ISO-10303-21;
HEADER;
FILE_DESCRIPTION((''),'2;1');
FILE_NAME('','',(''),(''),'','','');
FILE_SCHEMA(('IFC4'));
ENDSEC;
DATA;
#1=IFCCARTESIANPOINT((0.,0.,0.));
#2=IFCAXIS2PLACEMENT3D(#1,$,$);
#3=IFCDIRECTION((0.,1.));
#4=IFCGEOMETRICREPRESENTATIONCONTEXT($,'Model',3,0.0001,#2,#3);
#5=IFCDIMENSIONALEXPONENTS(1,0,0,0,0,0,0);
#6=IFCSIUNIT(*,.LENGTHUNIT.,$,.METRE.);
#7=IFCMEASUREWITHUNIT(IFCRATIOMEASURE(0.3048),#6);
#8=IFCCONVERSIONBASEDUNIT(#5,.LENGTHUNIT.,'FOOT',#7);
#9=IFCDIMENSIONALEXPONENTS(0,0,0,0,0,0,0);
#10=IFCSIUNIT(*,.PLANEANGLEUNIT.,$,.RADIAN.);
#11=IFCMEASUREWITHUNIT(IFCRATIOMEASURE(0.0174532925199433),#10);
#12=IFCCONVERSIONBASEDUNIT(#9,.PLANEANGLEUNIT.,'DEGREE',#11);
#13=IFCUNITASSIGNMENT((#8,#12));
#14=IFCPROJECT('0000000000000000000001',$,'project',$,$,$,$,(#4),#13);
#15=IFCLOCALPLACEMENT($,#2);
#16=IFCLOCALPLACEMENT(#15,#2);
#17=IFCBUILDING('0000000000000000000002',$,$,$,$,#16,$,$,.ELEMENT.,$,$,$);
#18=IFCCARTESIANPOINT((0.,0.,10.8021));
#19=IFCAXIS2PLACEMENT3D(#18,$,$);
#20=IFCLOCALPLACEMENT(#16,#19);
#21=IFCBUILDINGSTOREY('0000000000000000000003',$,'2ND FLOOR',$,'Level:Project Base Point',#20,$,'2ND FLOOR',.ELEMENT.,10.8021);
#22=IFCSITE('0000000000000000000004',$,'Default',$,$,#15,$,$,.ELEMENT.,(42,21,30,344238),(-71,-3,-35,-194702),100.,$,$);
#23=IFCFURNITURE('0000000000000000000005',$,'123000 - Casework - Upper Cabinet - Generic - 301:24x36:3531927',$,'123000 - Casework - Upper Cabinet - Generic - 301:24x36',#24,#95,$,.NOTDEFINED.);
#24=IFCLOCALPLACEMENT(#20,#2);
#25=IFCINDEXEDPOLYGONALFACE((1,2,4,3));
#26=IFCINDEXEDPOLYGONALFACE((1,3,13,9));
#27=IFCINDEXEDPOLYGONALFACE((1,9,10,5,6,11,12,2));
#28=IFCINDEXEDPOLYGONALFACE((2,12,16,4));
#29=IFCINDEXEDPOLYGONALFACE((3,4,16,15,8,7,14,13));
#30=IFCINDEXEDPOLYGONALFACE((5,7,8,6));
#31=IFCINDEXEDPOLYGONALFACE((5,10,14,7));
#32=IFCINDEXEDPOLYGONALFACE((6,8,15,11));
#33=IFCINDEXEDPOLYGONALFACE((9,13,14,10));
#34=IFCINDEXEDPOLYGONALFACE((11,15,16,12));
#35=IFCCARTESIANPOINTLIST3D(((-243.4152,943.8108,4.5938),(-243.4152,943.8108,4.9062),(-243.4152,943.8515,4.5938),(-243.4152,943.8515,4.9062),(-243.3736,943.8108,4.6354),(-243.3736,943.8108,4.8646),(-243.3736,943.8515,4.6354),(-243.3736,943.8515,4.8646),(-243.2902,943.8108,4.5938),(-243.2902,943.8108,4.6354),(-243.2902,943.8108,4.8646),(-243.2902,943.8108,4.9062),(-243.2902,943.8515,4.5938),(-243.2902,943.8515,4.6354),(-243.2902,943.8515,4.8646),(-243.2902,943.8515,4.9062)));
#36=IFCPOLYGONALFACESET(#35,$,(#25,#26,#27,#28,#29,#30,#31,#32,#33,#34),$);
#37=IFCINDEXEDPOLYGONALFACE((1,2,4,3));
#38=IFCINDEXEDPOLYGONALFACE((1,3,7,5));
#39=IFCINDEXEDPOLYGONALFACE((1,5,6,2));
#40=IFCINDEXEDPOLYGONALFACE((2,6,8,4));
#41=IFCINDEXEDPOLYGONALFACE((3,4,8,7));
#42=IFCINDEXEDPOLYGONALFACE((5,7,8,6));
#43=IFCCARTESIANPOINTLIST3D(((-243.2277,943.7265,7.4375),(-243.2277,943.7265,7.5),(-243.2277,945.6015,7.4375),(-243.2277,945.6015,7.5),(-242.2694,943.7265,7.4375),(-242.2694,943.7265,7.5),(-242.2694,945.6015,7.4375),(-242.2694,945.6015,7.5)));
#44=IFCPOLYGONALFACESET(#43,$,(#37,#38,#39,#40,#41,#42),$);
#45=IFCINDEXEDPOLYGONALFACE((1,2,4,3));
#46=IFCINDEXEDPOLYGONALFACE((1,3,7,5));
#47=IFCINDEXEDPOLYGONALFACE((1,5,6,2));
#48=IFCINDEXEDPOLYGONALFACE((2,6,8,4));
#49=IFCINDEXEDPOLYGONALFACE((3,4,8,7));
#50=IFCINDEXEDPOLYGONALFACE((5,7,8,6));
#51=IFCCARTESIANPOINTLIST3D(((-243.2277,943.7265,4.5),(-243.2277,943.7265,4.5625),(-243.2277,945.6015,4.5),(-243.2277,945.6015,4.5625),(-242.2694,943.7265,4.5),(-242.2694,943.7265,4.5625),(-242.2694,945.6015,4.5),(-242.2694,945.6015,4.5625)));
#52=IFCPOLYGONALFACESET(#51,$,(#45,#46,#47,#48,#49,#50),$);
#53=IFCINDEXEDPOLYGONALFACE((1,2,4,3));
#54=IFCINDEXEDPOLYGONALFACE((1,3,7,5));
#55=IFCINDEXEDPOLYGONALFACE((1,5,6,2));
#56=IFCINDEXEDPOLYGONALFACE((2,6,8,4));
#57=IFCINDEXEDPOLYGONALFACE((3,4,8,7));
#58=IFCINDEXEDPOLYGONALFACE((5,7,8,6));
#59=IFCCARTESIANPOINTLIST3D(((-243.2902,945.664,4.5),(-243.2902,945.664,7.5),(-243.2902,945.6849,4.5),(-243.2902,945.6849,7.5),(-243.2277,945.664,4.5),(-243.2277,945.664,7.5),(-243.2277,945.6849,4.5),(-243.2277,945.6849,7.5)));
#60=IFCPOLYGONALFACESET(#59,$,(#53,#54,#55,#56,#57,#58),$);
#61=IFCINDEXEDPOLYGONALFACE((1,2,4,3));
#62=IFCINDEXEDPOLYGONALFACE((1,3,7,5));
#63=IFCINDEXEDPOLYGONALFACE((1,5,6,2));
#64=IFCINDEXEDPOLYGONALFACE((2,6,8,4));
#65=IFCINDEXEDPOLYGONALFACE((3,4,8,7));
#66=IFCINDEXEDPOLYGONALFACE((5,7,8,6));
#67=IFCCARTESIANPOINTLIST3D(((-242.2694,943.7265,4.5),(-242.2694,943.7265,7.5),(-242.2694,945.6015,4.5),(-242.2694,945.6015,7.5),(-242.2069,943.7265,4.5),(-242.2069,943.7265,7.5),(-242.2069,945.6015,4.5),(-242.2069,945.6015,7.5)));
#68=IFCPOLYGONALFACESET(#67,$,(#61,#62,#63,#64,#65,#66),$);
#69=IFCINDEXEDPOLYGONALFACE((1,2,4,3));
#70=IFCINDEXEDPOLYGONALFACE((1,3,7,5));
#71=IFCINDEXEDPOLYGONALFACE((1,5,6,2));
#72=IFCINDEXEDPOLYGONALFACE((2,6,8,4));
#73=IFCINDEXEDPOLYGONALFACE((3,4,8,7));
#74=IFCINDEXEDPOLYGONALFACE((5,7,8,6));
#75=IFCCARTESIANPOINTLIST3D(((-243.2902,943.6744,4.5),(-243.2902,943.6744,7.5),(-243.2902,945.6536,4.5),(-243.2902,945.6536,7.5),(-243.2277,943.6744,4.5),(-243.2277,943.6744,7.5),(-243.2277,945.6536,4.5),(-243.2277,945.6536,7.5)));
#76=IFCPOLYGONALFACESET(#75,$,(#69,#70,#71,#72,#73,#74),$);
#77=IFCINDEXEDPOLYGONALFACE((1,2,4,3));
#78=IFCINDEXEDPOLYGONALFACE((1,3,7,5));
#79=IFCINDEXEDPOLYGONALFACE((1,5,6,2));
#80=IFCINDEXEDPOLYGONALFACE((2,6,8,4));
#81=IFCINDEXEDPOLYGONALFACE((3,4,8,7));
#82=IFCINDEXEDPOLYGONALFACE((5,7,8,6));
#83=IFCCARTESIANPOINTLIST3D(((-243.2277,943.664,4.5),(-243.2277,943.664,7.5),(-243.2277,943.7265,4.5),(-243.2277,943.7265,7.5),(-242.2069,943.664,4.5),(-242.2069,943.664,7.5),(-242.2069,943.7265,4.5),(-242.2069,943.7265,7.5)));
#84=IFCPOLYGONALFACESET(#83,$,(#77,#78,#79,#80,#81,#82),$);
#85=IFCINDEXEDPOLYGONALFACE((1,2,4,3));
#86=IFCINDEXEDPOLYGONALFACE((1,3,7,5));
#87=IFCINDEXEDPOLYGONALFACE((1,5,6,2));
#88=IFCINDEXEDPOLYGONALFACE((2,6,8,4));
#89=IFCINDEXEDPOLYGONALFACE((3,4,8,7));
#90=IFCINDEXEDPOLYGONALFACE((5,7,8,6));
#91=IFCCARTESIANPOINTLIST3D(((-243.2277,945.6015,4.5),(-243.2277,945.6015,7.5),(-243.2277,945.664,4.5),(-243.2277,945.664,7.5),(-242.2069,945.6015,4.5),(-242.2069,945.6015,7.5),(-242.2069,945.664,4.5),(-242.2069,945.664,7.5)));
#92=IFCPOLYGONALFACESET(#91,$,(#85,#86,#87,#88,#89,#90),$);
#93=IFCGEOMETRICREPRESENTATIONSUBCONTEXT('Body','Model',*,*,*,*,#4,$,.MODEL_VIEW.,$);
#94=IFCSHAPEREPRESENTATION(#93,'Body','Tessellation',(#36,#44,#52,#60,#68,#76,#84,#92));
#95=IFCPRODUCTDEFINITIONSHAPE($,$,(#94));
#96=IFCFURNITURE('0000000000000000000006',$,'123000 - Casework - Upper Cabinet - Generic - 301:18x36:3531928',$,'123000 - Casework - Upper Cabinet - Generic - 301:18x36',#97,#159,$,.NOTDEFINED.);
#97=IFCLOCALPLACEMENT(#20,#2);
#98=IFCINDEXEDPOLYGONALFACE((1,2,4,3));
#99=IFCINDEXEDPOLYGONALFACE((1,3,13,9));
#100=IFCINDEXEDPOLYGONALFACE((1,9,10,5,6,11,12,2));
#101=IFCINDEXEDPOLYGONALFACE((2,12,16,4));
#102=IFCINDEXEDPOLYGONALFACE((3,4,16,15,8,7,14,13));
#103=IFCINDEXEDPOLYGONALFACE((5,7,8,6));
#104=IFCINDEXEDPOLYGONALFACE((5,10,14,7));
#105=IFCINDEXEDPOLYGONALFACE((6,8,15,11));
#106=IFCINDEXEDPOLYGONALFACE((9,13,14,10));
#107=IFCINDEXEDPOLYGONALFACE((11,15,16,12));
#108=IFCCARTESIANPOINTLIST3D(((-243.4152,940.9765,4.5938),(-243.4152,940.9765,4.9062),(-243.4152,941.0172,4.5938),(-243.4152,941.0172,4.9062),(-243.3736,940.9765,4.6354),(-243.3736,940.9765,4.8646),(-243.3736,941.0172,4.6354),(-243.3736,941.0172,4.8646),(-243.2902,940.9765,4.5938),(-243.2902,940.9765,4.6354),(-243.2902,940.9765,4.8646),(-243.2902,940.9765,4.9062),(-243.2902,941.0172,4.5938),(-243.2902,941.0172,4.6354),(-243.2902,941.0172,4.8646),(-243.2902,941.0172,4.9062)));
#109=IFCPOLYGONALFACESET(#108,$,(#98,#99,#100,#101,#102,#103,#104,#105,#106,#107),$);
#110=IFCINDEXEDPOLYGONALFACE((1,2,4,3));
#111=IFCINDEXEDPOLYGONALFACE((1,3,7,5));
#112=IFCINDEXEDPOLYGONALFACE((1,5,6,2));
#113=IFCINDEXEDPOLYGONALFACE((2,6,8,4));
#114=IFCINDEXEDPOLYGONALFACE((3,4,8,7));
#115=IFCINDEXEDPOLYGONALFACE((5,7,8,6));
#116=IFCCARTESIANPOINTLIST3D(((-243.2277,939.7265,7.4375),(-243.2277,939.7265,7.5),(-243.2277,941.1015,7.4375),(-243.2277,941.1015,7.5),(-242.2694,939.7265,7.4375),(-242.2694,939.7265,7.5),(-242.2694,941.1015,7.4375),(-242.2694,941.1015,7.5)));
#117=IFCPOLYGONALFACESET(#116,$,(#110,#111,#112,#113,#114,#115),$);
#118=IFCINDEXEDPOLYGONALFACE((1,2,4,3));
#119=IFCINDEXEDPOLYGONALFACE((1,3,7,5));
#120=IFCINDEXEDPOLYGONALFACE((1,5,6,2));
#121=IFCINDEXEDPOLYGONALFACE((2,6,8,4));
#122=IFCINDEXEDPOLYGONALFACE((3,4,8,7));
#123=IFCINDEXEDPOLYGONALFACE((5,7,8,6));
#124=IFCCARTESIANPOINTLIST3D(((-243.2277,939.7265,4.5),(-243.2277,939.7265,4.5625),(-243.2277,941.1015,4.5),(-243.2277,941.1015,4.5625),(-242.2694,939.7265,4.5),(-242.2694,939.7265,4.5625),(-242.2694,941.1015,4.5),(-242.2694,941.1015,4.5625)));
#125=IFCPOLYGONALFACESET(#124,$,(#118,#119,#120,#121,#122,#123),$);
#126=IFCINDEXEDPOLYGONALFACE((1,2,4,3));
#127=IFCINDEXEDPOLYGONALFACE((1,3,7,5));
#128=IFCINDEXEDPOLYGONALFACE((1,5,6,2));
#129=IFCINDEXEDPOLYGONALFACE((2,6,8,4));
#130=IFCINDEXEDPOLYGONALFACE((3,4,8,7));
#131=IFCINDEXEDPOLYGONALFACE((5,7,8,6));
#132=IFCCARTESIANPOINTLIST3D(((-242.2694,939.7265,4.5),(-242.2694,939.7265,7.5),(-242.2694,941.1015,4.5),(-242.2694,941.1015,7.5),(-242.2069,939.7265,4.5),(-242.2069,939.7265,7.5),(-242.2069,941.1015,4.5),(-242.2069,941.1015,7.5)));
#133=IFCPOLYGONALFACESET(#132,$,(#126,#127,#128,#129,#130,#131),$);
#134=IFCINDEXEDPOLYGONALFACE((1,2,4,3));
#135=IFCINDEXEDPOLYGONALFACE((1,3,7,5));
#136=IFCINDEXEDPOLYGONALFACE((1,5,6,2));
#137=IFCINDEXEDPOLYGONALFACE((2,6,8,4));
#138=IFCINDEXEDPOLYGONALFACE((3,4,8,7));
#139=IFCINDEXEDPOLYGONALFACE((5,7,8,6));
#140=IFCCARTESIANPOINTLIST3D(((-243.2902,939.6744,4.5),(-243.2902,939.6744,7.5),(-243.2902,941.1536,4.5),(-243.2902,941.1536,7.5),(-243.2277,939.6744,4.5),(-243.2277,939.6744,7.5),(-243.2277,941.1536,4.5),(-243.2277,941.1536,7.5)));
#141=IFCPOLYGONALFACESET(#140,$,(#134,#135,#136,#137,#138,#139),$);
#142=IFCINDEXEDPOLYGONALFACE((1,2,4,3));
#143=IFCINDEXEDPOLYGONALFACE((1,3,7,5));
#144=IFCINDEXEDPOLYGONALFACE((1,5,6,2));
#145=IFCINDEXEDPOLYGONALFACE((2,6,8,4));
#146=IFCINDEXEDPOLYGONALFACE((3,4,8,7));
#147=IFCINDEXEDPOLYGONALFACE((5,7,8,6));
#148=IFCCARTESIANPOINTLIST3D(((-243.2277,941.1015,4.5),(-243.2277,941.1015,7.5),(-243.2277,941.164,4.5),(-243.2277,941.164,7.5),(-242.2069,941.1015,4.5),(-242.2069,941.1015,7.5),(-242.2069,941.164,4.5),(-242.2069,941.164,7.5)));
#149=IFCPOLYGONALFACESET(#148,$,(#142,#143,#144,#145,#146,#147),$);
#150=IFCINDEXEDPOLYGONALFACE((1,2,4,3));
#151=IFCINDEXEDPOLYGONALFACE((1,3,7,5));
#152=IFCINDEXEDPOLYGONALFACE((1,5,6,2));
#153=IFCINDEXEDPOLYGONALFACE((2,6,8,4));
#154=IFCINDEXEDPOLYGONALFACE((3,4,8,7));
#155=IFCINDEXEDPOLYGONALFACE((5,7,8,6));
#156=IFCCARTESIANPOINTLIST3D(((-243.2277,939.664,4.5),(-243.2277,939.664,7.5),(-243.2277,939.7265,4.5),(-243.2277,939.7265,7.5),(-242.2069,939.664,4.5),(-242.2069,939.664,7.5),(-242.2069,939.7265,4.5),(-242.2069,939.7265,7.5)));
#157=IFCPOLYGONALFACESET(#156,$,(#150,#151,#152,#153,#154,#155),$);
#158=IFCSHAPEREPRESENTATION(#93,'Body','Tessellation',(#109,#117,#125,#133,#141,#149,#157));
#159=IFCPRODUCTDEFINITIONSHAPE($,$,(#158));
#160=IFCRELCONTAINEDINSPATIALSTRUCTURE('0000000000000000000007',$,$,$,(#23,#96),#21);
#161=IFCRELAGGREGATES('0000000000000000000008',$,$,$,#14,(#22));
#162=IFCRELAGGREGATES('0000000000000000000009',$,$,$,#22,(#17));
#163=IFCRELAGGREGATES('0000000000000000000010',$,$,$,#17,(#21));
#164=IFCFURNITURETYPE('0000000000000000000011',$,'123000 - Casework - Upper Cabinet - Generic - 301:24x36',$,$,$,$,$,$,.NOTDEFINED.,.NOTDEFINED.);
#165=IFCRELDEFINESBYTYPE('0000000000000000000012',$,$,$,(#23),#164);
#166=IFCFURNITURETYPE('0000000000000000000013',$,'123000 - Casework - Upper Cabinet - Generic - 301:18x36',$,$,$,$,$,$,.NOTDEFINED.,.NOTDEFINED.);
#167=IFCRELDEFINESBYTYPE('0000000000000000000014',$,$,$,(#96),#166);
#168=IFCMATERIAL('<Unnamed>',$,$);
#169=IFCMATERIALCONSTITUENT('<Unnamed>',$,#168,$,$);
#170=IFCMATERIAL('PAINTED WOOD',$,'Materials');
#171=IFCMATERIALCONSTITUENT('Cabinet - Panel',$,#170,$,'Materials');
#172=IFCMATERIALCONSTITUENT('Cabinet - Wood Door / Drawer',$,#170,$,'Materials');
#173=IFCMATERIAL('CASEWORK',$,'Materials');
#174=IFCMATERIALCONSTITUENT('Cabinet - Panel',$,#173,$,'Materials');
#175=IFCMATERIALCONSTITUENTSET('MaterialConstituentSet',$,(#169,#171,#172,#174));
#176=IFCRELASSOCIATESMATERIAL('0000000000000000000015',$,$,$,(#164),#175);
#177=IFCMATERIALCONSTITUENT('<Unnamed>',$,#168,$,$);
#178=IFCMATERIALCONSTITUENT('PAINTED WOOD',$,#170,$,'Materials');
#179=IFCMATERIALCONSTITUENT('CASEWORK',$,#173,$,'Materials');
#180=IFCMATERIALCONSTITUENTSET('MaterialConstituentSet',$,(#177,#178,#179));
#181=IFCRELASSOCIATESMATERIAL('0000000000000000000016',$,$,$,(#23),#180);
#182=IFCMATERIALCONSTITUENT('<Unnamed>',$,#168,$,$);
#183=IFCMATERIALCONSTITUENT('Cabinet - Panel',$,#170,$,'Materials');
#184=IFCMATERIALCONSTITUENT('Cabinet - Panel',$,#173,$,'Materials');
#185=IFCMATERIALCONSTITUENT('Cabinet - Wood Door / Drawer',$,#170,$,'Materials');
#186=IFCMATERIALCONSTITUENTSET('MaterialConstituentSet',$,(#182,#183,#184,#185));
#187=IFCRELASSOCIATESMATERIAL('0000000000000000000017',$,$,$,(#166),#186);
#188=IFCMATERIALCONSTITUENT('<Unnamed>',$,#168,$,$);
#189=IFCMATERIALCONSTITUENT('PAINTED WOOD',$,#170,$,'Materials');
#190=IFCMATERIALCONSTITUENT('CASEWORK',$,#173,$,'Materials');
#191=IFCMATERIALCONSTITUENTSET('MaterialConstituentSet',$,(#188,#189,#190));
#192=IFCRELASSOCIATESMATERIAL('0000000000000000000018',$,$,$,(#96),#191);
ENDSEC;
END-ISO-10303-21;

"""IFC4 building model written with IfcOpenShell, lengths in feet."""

from ifc_helpers import new_model, entity, si_unit, converted_unit, direction, frame, frame_2d, origin, origin_2d_with_axis, place, context, subcontext, project, spatial, polyline, rectangle, outline, extrude, source, transform, mapped, material, constituent, constituent_set, type_object, type_shapes, element, save


model = new_model("IFC4")

# Units and contexts
model_context = context("Model", 3, precision=0.0001, world=origin(), true_north=direction((0.0, 1.0)))
body_context = subcontext(model_context, "Body", "Model", "MODEL_VIEW")
ifc_project = project(units=[converted_unit("LENGTHUNIT", "FOOT", entity("IfcRatioMeasure", 0.3048), si_unit("LENGTHUNIT", "METRE"), dimensions=[1, 0, 0, 0, 0, 0, 0]), converted_unit("PLANEANGLEUNIT", "DEGREE", entity("IfcRatioMeasure", 0.0174532925199433), si_unit("PLANEANGLEUNIT", "RADIAN"), dimensions=[0, 0, 0, 0, 0, 0, 0])], contexts=[model_context])

# Site, building, storey
site_placement = place(None, origin())
site = spatial("IfcSite", under=ifc_project, at=site_placement, Name="Default", CompositionType="ELEMENT", RefLatitude=(42, 21, 30, 344238), RefLongitude=(-71, -3, -35, -194702), RefElevation=100.0)
building_placement = place(site_placement, origin())
building = spatial("IfcBuilding", under=site, at=building_placement, CompositionType="ELEMENT")
storey_placement = place(building_placement, frame((0.0, 0.0, 10.8021)))
storey = spatial("IfcBuildingStorey", under=building, at=storey_placement, Name="2ND FLOOR", ObjectType="Level:Project Base Point", LongName="2ND FLOOR", CompositionType="ELEMENT", Elevation=10.8021)

# Furniture
ifc_material_1 = material(Name="CASEWORK", Category="Materials")
ifc_material_2 = material(Name="<Unnamed>")
ifc_material_3 = material(Name="PAINTED WOOD", Category="Materials")
ifc_constituent_1 = constituent(ifc_material_2, Name="<Unnamed>")
ifc_constituent_2 = constituent(ifc_material_3, Name="PAINTED WOOD", Category="Materials")
ifc_constituent_3 = constituent(ifc_material_1, Name="CASEWORK", Category="Materials")
ifc_constituent_set_1 = constituent_set(constituents=[ifc_constituent_1, ifc_constituent_2, ifc_constituent_3], Name="MaterialConstituentSet")
ifc_constituent_4 = constituent(ifc_material_2, Name="<Unnamed>")
ifc_constituent_5 = constituent(ifc_material_3, Name="Cabinet - Panel", Category="Materials")
ifc_constituent_6 = constituent(ifc_material_3, Name="Cabinet - Wood Door / Drawer", Category="Materials")
ifc_constituent_7 = constituent(ifc_material_1, Name="Cabinet - Panel", Category="Materials")
ifc_constituent_set_2 = constituent_set(constituents=[ifc_constituent_4, ifc_constituent_5, ifc_constituent_6, ifc_constituent_7], Name="MaterialConstituentSet")
furniture_type_1 = type_object("IfcFurnitureType", Name="123000 - Casework - Upper Cabinet - Generic - 301:24x36", AssemblyPlace="NOTDEFINED", PredefinedType="NOTDEFINED", material=ifc_constituent_set_2)
shared_shape_1 = source(origin(), body_context, "Body", "SweptSolid", [
    extrude(outline(polyline([(-0.0521, -0.1146), (-0.0521, -0.1562), (0.0729, -0.1562), (0.0729, 0.1562), (-0.0521, 0.1562), (-0.0521, 0.1146), (0.0313, 0.1146), (0.0313, -0.1146), (-0.0521, -0.1146)])), frame((0.1468, 1.1354, 0.25), z_axis=(-1.0, 0.0, 0.0), x_axis=(0.0, 1.0, 0.0)), (0.0, 0.0, -1.0), 0.0407),
    extrude(rectangle(XDim=0.9583, YDim=1.875, at=frame_2d((0.0, 0.0), x_axis=(1.0, 0.0))), frame((1.0, 0.5417, 2.9375), z_axis=(0.0, 0.0, 1.0), x_axis=(0.0, 1.0, 0.0)), (0.0, 0.0, 1.0), 0.0625),
    extrude(rectangle(XDim=0.9583, YDim=1.875, at=frame_2d((0.0, 0.0), x_axis=(1.0, 0.0))), frame((1.0, 0.5417, 0.0), z_axis=(0.0, 0.0, 1.0), x_axis=(0.0, 1.0, 0.0)), (0.0, 0.0, 1.0), 0.0625),
    extrude(rectangle(XDim=0.0208, YDim=0.0625, at=frame_2d((0.0, 0.0), x_axis=(1.0, 0.0))), frame((2.0104, 1.0521, 0.0)), (0.0, 0.0, 1.0), 3.0),
    extrude(rectangle(XDim=1.875, YDim=0.0625, at=origin_2d_with_axis()), frame((1.0, 0.0313, 0.0), z_axis=(0.0, 0.0, 1.0), x_axis=(-1.0, 0.0, 0.0)), (0.0, 0.0, 1.0), 3.0),
    extrude(rectangle(XDim=1.9792, YDim=0.0625, at=frame_2d((0.0, 0.0), x_axis=(1.0, 0.0))), frame((1.0, 1.0521, 0.0)), (0.0, 0.0, 1.0), 3.0),
    extrude(rectangle(XDim=1.0208, YDim=0.0625, at=origin_2d_with_axis()), frame((0.0312, 0.5104, 0.0), z_axis=(0.0, 0.0, 1.0), x_axis=(0.0, 1.0, 0.0)), (0.0, 0.0, 1.0), 3.0),
    extrude(rectangle(XDim=1.0208, YDim=0.0625, at=origin_2d_with_axis()), frame((1.9688, 0.5104, 0.0), z_axis=(0.0, 0.0, 1.0), x_axis=(0.0, 1.0, 0.0)), (0.0, 0.0, 1.0), 3.0),
])
type_shapes(furniture_type_1, [shared_shape_1])
furniture_1_placement = place(storey_placement, frame((-242.2069, 943.664, 4.5), z_axis=(0.0, 0.0, 1.0), x_axis=(0.0, 1.0, 0.0)))
element("IfcFurniture", 1, at=furniture_1_placement, inside=storey, type_object=furniture_type_1, material=ifc_constituent_set_1, Name="123000 - Casework - Upper Cabinet - Generic - 301:24x36:3531927", ObjectType="123000 - Casework - Upper Cabinet - Generic - 301:24x36", PredefinedType="NOTDEFINED", context=body_context, shape_type="MappedRepresentation", body=[
    mapped(shared_shape_1, transform((0.0, 0.0, 0.0), scale=1.0)),
])
ifc_constituent_8 = constituent(ifc_material_2, Name="<Unnamed>")
ifc_constituent_9 = constituent(ifc_material_3, Name="PAINTED WOOD", Category="Materials")
ifc_constituent_10 = constituent(ifc_material_1, Name="CASEWORK", Category="Materials")
ifc_constituent_set_3 = constituent_set(constituents=[ifc_constituent_8, ifc_constituent_9, ifc_constituent_10], Name="MaterialConstituentSet")
ifc_constituent_11 = constituent(ifc_material_2, Name="<Unnamed>")
ifc_constituent_12 = constituent(ifc_material_3, Name="Cabinet - Panel", Category="Materials")
ifc_constituent_13 = constituent(ifc_material_1, Name="Cabinet - Panel", Category="Materials")
ifc_constituent_14 = constituent(ifc_material_3, Name="Cabinet - Wood Door / Drawer", Category="Materials")
ifc_constituent_set_4 = constituent_set(constituents=[ifc_constituent_11, ifc_constituent_12, ifc_constituent_13, ifc_constituent_14], Name="MaterialConstituentSet")
furniture_type_2 = type_object("IfcFurnitureType", Name="123000 - Casework - Upper Cabinet - Generic - 301:18x36", AssemblyPlace="NOTDEFINED", PredefinedType="NOTDEFINED", material=ifc_constituent_set_4)
shared_shape_2 = source(origin(), body_context, "Body", "SweptSolid", [
    extrude(outline(polyline([(0.1146, -0.0521), (0.1562, -0.0521), (0.1562, 0.0729), (-0.1562, 0.0729), (-0.1562, -0.0521), (-0.1146, -0.0521), (-0.1146, 0.0313), (0.1146, 0.0313), (0.1146, -0.0521)])), frame((0.1468, 0.0729, 0.25), z_axis=(1.0, 0.0, 0.0), x_axis=(0.0, 0.0, 1.0)), (0.0, 0.0, 1.0), 0.0407),
    extrude(rectangle(XDim=1.375, YDim=0.9583, at=frame_2d((0.0, 0.0), x_axis=(1.0, 0.0))), frame((0.75, 0.6666, 2.9375), z_axis=(0.0, 0.0, 1.0), x_axis=(-1.0, 0.0, 0.0)), (0.0, 0.0, 1.0), 0.0625),
    extrude(rectangle(XDim=1.375, YDim=0.9583, at=frame_2d((0.0, 0.0), x_axis=(1.0, 0.0))), frame((0.75, 0.6666, 0.0), z_axis=(0.0, 0.0, 1.0), x_axis=(-1.0, 0.0, 0.0)), (0.0, 0.0, 1.0), 0.0625),
    extrude(rectangle(XDim=0.0625, YDim=1.375, at=origin_2d_with_axis()), frame((0.75, 1.177, 0.0), z_axis=(0.0, 0.0, 1.0), x_axis=(0.0, 1.0, 0.0)), (0.0, 0.0, 1.0), 3.0),
    extrude(rectangle(XDim=0.0625, YDim=1.4792, at=origin_2d_with_axis()), frame((0.75, 0.1562, 0.0), z_axis=(0.0, 0.0, 1.0), x_axis=(0.0, -1.0, 0.0)), (0.0, 0.0, 1.0), 3.0),
    extrude(rectangle(XDim=0.0625, YDim=1.0208, at=origin_2d_with_axis()), frame((0.0312, 0.6979, 0.0), z_axis=(0.0, 0.0, 1.0), x_axis=(-1.0, 0.0, 0.0)), (0.0, 0.0, 1.0), 3.0),
    extrude(rectangle(XDim=0.0625, YDim=1.0208, at=origin_2d_with_axis()), frame((1.4688, 0.6979, 0.0), z_axis=(0.0, 0.0, 1.0), x_axis=(-1.0, 0.0, 0.0)), (0.0, 0.0, 1.0), 3.0),
])
type_shapes(furniture_type_2, [shared_shape_2])
furniture_2_placement = place(storey_placement, frame((-243.4152, 941.164, 4.5), z_axis=(0.0, 0.0, 1.0), x_axis=(0.0, -1.0, 0.0)))
element("IfcFurniture", 2, at=furniture_2_placement, inside=storey, type_object=furniture_type_2, material=ifc_constituent_set_3, Name="123000 - Casework - Upper Cabinet - Generic - 301:18x36:3531928", ObjectType="123000 - Casework - Upper Cabinet - Generic - 301:18x36", PredefinedType="NOTDEFINED", context=body_context, shape_type="MappedRepresentation", body=[
    mapped(shared_shape_2, transform((0.0, 0.0, 0.0), scale=1.0)),
])

save(model, "model.ifc")
